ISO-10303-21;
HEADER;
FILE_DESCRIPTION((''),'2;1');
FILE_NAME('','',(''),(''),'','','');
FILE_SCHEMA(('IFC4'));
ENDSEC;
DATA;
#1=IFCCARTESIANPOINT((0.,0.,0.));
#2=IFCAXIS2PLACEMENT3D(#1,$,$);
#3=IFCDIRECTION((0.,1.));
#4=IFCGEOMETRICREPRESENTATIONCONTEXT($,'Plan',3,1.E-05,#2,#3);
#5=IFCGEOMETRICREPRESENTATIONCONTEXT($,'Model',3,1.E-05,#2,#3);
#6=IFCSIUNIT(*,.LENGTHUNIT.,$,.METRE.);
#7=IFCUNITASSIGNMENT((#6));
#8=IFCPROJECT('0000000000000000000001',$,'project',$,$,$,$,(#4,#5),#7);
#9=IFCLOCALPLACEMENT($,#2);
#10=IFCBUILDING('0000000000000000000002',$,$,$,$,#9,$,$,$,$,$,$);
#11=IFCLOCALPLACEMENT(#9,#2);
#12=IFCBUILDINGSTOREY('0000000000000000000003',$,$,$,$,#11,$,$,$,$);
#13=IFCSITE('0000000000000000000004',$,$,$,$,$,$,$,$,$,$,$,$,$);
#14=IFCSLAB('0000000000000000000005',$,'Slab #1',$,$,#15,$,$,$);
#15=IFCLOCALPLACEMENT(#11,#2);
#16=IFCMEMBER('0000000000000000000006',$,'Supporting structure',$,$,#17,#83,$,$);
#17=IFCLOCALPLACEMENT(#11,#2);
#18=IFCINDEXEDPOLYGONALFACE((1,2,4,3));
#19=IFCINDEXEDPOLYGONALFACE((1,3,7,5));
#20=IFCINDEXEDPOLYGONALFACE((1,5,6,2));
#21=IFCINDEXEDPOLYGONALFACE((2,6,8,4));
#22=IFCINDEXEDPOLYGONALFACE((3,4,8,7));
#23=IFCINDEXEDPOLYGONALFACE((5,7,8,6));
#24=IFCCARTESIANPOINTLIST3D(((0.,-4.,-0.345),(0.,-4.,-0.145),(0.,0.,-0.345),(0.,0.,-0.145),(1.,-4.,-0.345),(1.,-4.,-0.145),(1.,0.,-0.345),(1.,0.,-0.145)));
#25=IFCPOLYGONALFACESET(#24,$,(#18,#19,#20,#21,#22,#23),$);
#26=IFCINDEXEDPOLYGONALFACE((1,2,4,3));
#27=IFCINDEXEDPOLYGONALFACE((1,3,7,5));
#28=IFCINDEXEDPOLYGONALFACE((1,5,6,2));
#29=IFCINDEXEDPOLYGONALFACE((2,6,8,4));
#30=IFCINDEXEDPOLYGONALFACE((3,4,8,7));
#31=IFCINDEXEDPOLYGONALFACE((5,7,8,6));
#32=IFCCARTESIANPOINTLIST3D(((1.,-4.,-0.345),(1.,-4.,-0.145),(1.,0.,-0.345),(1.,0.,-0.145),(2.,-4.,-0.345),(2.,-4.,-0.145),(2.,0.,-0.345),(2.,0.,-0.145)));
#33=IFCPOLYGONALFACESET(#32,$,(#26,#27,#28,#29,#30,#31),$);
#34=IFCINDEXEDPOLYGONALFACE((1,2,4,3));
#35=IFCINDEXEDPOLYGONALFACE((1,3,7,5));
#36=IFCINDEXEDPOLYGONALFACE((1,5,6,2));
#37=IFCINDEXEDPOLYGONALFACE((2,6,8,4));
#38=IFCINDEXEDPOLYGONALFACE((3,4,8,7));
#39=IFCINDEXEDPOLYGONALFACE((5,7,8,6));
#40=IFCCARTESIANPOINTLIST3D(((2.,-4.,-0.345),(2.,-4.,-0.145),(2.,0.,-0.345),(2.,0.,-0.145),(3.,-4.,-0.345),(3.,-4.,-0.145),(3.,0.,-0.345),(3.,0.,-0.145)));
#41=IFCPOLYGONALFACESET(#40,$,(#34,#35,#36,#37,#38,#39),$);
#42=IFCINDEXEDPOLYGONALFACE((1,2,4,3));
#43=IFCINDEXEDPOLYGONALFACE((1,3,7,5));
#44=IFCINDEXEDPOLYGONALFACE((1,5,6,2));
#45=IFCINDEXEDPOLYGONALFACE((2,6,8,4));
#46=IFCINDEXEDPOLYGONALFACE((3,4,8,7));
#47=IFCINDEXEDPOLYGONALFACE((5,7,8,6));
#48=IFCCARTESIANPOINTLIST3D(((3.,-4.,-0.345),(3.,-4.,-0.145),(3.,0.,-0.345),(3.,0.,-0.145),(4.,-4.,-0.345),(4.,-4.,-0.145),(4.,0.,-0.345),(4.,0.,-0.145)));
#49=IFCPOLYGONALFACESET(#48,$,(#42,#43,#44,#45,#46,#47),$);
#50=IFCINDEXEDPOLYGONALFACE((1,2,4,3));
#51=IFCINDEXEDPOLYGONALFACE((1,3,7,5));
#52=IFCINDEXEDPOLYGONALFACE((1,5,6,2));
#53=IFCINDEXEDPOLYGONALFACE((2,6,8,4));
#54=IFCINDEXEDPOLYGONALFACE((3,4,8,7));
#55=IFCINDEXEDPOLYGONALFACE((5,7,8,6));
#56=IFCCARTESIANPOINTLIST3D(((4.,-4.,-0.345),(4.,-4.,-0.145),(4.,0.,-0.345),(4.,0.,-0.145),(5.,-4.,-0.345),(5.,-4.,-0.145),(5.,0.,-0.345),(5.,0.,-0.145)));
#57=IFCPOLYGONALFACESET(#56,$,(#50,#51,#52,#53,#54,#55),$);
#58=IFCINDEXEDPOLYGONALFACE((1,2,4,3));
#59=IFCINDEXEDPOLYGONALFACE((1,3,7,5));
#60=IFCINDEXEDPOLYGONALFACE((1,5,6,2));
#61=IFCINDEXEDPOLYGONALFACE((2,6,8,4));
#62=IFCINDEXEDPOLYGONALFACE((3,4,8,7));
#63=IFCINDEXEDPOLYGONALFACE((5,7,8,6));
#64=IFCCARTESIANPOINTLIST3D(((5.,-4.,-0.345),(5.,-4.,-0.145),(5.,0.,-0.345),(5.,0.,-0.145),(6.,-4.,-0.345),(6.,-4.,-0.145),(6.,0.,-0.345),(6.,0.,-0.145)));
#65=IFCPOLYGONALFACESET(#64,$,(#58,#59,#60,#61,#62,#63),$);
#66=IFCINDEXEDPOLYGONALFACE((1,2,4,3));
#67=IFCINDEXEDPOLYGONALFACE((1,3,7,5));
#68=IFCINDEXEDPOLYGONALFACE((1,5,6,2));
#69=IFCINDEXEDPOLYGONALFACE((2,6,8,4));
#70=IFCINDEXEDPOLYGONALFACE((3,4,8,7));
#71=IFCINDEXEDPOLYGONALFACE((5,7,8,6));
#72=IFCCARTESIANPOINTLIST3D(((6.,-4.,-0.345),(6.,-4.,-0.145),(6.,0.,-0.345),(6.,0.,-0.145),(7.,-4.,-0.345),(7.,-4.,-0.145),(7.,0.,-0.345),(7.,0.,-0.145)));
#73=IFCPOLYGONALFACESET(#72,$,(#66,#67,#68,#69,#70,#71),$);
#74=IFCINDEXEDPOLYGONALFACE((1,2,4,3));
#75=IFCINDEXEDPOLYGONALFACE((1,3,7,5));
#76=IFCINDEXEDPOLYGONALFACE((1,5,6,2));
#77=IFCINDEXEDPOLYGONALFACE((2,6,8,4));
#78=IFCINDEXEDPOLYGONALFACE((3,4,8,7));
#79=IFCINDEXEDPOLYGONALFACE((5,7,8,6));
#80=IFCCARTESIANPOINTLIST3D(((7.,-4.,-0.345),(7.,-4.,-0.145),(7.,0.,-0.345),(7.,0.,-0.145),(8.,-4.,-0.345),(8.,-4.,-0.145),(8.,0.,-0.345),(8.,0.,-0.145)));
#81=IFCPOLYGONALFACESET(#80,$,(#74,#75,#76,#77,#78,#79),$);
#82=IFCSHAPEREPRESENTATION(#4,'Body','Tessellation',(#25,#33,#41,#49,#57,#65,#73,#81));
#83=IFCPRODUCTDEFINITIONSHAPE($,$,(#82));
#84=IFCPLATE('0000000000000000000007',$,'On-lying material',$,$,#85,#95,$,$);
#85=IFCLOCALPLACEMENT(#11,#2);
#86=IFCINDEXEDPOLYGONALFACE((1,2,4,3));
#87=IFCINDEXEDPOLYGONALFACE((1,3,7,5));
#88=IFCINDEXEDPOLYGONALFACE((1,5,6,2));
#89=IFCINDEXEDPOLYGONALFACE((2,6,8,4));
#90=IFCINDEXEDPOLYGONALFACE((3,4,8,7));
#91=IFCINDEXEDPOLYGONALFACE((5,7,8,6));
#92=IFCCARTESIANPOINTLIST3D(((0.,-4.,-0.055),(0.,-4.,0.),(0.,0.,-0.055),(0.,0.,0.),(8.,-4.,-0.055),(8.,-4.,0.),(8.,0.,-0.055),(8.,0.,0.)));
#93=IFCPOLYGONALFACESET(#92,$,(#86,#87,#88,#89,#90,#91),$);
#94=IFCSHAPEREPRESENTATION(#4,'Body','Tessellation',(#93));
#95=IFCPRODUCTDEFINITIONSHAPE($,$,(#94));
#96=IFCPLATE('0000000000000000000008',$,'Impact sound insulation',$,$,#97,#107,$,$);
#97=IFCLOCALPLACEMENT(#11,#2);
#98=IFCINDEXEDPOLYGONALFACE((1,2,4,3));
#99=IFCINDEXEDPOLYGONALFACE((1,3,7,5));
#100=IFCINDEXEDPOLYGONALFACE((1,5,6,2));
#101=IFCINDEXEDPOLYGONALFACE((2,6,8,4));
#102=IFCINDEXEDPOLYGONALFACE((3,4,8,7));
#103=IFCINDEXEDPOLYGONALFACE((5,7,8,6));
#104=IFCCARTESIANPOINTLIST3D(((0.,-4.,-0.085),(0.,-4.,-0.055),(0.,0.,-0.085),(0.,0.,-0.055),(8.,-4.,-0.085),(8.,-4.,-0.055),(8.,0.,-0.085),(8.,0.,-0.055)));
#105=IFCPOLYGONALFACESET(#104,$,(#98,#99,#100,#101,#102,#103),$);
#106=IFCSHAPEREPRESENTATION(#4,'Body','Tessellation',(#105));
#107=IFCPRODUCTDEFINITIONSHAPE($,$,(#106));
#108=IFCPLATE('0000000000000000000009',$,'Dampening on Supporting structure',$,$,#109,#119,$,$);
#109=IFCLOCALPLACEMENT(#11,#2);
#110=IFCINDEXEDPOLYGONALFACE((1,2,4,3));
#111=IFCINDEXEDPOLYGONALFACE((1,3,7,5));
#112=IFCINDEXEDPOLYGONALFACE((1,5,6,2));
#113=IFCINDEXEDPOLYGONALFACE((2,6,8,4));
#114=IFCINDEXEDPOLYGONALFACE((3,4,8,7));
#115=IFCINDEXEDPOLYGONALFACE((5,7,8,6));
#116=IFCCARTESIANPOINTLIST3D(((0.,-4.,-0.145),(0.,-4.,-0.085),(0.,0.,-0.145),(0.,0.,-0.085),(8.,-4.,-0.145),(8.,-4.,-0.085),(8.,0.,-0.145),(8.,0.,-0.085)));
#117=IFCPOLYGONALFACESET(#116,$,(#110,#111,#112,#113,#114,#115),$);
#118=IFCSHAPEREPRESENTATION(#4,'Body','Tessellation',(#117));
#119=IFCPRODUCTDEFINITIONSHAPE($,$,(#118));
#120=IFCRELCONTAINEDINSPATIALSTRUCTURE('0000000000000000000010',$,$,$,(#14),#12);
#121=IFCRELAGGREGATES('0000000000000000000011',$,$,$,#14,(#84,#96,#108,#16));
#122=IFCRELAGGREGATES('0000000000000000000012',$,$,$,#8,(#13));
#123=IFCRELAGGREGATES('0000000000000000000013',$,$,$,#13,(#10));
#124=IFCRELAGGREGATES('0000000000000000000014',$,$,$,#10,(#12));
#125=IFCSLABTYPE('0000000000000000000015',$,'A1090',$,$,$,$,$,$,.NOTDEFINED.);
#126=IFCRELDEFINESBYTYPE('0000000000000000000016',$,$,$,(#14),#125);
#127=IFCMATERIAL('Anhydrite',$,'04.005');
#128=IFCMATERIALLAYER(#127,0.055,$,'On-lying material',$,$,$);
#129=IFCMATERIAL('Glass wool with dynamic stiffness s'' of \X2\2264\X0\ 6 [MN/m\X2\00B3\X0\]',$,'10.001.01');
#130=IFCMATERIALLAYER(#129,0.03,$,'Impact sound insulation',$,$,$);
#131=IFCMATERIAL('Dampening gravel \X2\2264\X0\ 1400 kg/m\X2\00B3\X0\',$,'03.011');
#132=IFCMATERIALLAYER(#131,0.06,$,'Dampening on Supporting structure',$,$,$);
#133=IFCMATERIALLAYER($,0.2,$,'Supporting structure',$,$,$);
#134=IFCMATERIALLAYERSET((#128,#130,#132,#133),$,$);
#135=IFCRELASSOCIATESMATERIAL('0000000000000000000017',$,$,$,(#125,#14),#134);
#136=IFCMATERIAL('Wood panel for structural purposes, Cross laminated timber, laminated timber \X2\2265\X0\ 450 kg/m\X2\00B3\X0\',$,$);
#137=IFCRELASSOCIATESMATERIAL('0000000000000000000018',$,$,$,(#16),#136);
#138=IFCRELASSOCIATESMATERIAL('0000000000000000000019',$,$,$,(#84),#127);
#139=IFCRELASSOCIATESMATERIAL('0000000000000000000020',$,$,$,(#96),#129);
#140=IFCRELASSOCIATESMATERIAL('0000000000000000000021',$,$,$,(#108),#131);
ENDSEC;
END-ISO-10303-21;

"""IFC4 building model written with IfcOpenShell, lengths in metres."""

from ifc_helpers import new_model, si_unit, direction, frame, frame_2d, origin, origin_with_axes, place, context, project, spatial, rectangle, extrude, material, layer, layer_set, type_object, element, aggregate, save


model = new_model("IFC4")

# Units and contexts
plan_context = context("Plan", 3, precision=1e-05, world=origin(), true_north=direction((0.0, 1.0)))
model_context = context("Model", 3, precision=1e-05, world=origin(), true_north=direction((0.0, 1.0)))
ifc_project = project(units=[si_unit("LENGTHUNIT", "METRE")], contexts=[plan_context, model_context])

# Site, building, storey
site = spatial("IfcSite", under=ifc_project)
building_placement = place(None, origin())
building = spatial("IfcBuilding", under=site, at=building_placement)
storey_placement = place(building_placement, origin())
storey = spatial("IfcBuildingStorey", under=building, at=storey_placement)

# Slab, member, plates
ifc_material_1 = material(Name="Anhydrite", Category="04.005")
ifc_layer_1 = layer(ifc_material_1, 0.055, Name="On-lying material")
ifc_material_2 = material(Name="Glass wool with dynamic stiffness s' of ≤ 6 [MN/m³]", Category="10.001.01")
ifc_layer_2 = layer(ifc_material_2, 0.03, Name="Impact sound insulation")
ifc_material_3 = material(Name="Dampening gravel ≤ 1400 kg/m³", Category="03.011")
ifc_layer_3 = layer(ifc_material_3, 0.06, Name="Dampening on Supporting structure")
ifc_layer_4 = layer(None, 0.2, Name="Supporting structure")
ifc_layer_set = layer_set([ifc_layer_1, ifc_layer_2, ifc_layer_3, ifc_layer_4])
slab_type = type_object("IfcSlabType", Name="A1090", PredefinedType="NOTDEFINED", material=ifc_layer_set)
slab_placement = place(None, frame((0.0, 0.0, 0.0), z_axis=(0.0, 0.0, -1.0), x_axis=(1.0, 0.0, 0.0)))
slab = element("IfcSlab", 1, at=slab_placement, inside=storey, type_object=slab_type, material=ifc_layer_set, Name="Slab #1")
ifc_material_4 = material(Name="Wood panel for structural purposes, Cross laminated timber, laminated timber ≥ 450 kg/m³")
member_placement = place(slab_placement, origin())
member = element("IfcMember", 2, at=member_placement, material=ifc_material_4, Name="Supporting structure", context=plan_context, shape_type="SweptSolid", body=[
    extrude(rectangle(XDim=1.0, YDim=0.2, at=frame_2d((0.5, 0.1), x_axis=(1.0, 0.0))), frame((0.0, 4.0, 0.145), z_axis=(0.0, -1.0, 0.0), x_axis=(1.0, 0.0, 0.0)), (0.0, 0.0, 1.0), 4.0),
    extrude(rectangle(XDim=1.0, YDim=0.2, at=frame_2d((0.5, 0.1), x_axis=(1.0, 0.0))), frame((1.0, 4.0, 0.145), z_axis=(0.0, -1.0, 0.0), x_axis=(1.0, 0.0, 0.0)), (0.0, 0.0, 1.0), 4.0),
    extrude(rectangle(XDim=1.0, YDim=0.2, at=frame_2d((0.5, 0.1), x_axis=(1.0, 0.0))), frame((2.0, 4.0, 0.145), z_axis=(0.0, -1.0, 0.0), x_axis=(1.0, 0.0, 0.0)), (0.0, 0.0, 1.0), 4.0),
    extrude(rectangle(XDim=1.0, YDim=0.2, at=frame_2d((0.5, 0.1), x_axis=(1.0, 0.0))), frame((3.0, 4.0, 0.145), z_axis=(0.0, -1.0, 0.0), x_axis=(1.0, 0.0, 0.0)), (0.0, 0.0, 1.0), 4.0),
    extrude(rectangle(XDim=1.0, YDim=0.2, at=frame_2d((0.5, 0.1), x_axis=(1.0, 0.0))), frame((4.0, 4.0, 0.145), z_axis=(0.0, -1.0, 0.0), x_axis=(1.0, 0.0, 0.0)), (0.0, 0.0, 1.0), 4.0),
    extrude(rectangle(XDim=1.0, YDim=0.2, at=frame_2d((0.5, 0.1), x_axis=(1.0, 0.0))), frame((5.0, 4.0, 0.145), z_axis=(0.0, -1.0, 0.0), x_axis=(1.0, 0.0, 0.0)), (0.0, 0.0, 1.0), 4.0),
    extrude(rectangle(XDim=1.0, YDim=0.2, at=frame_2d((0.5, 0.1), x_axis=(1.0, 0.0))), frame((6.0, 4.0, 0.145), z_axis=(0.0, -1.0, 0.0), x_axis=(1.0, 0.0, 0.0)), (0.0, 0.0, 1.0), 4.0),
    extrude(rectangle(XDim=1.0, YDim=0.2, at=frame_2d((0.5, 0.1), x_axis=(1.0, 0.0))), frame((7.0, 4.0, 0.145), z_axis=(0.0, -1.0, 0.0), x_axis=(1.0, 0.0, 0.0)), (0.0, 0.0, 1.0), 4.0),
])
plate_1_placement = place(slab_placement, origin())
plate_1 = element("IfcPlate", 3, at=plate_1_placement, material=ifc_material_1, Name="On-lying material", context=plan_context, shape_type="SweptSolid", body=[
    extrude(rectangle(XDim=8.0, YDim=4.0, at=frame_2d((4.0, 2.0), x_axis=(1.0, 0.0))), origin_with_axes(), (0.0, 0.0, 1.0), 0.055),
])
plate_2_placement = place(slab_placement, origin())
plate_2 = element("IfcPlate", 4, at=plate_2_placement, material=ifc_material_2, Name="Impact sound insulation", context=plan_context, shape_type="SweptSolid", body=[
    extrude(rectangle(XDim=8.0, YDim=4.0, at=frame_2d((4.0, 2.0), x_axis=(1.0, 0.0))), frame((0.0, 0.0, 0.055), z_axis=(0.0, 0.0, 1.0), x_axis=(1.0, 0.0, 0.0)), (0.0, 0.0, 1.0), 0.03),
])
plate_3_placement = place(slab_placement, origin())
plate_3 = element("IfcPlate", 5, at=plate_3_placement, material=ifc_material_3, Name="Dampening on Supporting structure", context=plan_context, shape_type="SweptSolid", body=[
    extrude(rectangle(XDim=8.0, YDim=4.0, at=frame_2d((4.0, 2.0), x_axis=(1.0, 0.0))), frame((0.0, 0.0, 0.085), z_axis=(0.0, 0.0, 1.0), x_axis=(1.0, 0.0, 0.0)), (0.0, 0.0, 1.0), 0.06),
])
aggregate(slab, [plate_1, plate_2, plate_3, member])

save(model, "model.ifc")
